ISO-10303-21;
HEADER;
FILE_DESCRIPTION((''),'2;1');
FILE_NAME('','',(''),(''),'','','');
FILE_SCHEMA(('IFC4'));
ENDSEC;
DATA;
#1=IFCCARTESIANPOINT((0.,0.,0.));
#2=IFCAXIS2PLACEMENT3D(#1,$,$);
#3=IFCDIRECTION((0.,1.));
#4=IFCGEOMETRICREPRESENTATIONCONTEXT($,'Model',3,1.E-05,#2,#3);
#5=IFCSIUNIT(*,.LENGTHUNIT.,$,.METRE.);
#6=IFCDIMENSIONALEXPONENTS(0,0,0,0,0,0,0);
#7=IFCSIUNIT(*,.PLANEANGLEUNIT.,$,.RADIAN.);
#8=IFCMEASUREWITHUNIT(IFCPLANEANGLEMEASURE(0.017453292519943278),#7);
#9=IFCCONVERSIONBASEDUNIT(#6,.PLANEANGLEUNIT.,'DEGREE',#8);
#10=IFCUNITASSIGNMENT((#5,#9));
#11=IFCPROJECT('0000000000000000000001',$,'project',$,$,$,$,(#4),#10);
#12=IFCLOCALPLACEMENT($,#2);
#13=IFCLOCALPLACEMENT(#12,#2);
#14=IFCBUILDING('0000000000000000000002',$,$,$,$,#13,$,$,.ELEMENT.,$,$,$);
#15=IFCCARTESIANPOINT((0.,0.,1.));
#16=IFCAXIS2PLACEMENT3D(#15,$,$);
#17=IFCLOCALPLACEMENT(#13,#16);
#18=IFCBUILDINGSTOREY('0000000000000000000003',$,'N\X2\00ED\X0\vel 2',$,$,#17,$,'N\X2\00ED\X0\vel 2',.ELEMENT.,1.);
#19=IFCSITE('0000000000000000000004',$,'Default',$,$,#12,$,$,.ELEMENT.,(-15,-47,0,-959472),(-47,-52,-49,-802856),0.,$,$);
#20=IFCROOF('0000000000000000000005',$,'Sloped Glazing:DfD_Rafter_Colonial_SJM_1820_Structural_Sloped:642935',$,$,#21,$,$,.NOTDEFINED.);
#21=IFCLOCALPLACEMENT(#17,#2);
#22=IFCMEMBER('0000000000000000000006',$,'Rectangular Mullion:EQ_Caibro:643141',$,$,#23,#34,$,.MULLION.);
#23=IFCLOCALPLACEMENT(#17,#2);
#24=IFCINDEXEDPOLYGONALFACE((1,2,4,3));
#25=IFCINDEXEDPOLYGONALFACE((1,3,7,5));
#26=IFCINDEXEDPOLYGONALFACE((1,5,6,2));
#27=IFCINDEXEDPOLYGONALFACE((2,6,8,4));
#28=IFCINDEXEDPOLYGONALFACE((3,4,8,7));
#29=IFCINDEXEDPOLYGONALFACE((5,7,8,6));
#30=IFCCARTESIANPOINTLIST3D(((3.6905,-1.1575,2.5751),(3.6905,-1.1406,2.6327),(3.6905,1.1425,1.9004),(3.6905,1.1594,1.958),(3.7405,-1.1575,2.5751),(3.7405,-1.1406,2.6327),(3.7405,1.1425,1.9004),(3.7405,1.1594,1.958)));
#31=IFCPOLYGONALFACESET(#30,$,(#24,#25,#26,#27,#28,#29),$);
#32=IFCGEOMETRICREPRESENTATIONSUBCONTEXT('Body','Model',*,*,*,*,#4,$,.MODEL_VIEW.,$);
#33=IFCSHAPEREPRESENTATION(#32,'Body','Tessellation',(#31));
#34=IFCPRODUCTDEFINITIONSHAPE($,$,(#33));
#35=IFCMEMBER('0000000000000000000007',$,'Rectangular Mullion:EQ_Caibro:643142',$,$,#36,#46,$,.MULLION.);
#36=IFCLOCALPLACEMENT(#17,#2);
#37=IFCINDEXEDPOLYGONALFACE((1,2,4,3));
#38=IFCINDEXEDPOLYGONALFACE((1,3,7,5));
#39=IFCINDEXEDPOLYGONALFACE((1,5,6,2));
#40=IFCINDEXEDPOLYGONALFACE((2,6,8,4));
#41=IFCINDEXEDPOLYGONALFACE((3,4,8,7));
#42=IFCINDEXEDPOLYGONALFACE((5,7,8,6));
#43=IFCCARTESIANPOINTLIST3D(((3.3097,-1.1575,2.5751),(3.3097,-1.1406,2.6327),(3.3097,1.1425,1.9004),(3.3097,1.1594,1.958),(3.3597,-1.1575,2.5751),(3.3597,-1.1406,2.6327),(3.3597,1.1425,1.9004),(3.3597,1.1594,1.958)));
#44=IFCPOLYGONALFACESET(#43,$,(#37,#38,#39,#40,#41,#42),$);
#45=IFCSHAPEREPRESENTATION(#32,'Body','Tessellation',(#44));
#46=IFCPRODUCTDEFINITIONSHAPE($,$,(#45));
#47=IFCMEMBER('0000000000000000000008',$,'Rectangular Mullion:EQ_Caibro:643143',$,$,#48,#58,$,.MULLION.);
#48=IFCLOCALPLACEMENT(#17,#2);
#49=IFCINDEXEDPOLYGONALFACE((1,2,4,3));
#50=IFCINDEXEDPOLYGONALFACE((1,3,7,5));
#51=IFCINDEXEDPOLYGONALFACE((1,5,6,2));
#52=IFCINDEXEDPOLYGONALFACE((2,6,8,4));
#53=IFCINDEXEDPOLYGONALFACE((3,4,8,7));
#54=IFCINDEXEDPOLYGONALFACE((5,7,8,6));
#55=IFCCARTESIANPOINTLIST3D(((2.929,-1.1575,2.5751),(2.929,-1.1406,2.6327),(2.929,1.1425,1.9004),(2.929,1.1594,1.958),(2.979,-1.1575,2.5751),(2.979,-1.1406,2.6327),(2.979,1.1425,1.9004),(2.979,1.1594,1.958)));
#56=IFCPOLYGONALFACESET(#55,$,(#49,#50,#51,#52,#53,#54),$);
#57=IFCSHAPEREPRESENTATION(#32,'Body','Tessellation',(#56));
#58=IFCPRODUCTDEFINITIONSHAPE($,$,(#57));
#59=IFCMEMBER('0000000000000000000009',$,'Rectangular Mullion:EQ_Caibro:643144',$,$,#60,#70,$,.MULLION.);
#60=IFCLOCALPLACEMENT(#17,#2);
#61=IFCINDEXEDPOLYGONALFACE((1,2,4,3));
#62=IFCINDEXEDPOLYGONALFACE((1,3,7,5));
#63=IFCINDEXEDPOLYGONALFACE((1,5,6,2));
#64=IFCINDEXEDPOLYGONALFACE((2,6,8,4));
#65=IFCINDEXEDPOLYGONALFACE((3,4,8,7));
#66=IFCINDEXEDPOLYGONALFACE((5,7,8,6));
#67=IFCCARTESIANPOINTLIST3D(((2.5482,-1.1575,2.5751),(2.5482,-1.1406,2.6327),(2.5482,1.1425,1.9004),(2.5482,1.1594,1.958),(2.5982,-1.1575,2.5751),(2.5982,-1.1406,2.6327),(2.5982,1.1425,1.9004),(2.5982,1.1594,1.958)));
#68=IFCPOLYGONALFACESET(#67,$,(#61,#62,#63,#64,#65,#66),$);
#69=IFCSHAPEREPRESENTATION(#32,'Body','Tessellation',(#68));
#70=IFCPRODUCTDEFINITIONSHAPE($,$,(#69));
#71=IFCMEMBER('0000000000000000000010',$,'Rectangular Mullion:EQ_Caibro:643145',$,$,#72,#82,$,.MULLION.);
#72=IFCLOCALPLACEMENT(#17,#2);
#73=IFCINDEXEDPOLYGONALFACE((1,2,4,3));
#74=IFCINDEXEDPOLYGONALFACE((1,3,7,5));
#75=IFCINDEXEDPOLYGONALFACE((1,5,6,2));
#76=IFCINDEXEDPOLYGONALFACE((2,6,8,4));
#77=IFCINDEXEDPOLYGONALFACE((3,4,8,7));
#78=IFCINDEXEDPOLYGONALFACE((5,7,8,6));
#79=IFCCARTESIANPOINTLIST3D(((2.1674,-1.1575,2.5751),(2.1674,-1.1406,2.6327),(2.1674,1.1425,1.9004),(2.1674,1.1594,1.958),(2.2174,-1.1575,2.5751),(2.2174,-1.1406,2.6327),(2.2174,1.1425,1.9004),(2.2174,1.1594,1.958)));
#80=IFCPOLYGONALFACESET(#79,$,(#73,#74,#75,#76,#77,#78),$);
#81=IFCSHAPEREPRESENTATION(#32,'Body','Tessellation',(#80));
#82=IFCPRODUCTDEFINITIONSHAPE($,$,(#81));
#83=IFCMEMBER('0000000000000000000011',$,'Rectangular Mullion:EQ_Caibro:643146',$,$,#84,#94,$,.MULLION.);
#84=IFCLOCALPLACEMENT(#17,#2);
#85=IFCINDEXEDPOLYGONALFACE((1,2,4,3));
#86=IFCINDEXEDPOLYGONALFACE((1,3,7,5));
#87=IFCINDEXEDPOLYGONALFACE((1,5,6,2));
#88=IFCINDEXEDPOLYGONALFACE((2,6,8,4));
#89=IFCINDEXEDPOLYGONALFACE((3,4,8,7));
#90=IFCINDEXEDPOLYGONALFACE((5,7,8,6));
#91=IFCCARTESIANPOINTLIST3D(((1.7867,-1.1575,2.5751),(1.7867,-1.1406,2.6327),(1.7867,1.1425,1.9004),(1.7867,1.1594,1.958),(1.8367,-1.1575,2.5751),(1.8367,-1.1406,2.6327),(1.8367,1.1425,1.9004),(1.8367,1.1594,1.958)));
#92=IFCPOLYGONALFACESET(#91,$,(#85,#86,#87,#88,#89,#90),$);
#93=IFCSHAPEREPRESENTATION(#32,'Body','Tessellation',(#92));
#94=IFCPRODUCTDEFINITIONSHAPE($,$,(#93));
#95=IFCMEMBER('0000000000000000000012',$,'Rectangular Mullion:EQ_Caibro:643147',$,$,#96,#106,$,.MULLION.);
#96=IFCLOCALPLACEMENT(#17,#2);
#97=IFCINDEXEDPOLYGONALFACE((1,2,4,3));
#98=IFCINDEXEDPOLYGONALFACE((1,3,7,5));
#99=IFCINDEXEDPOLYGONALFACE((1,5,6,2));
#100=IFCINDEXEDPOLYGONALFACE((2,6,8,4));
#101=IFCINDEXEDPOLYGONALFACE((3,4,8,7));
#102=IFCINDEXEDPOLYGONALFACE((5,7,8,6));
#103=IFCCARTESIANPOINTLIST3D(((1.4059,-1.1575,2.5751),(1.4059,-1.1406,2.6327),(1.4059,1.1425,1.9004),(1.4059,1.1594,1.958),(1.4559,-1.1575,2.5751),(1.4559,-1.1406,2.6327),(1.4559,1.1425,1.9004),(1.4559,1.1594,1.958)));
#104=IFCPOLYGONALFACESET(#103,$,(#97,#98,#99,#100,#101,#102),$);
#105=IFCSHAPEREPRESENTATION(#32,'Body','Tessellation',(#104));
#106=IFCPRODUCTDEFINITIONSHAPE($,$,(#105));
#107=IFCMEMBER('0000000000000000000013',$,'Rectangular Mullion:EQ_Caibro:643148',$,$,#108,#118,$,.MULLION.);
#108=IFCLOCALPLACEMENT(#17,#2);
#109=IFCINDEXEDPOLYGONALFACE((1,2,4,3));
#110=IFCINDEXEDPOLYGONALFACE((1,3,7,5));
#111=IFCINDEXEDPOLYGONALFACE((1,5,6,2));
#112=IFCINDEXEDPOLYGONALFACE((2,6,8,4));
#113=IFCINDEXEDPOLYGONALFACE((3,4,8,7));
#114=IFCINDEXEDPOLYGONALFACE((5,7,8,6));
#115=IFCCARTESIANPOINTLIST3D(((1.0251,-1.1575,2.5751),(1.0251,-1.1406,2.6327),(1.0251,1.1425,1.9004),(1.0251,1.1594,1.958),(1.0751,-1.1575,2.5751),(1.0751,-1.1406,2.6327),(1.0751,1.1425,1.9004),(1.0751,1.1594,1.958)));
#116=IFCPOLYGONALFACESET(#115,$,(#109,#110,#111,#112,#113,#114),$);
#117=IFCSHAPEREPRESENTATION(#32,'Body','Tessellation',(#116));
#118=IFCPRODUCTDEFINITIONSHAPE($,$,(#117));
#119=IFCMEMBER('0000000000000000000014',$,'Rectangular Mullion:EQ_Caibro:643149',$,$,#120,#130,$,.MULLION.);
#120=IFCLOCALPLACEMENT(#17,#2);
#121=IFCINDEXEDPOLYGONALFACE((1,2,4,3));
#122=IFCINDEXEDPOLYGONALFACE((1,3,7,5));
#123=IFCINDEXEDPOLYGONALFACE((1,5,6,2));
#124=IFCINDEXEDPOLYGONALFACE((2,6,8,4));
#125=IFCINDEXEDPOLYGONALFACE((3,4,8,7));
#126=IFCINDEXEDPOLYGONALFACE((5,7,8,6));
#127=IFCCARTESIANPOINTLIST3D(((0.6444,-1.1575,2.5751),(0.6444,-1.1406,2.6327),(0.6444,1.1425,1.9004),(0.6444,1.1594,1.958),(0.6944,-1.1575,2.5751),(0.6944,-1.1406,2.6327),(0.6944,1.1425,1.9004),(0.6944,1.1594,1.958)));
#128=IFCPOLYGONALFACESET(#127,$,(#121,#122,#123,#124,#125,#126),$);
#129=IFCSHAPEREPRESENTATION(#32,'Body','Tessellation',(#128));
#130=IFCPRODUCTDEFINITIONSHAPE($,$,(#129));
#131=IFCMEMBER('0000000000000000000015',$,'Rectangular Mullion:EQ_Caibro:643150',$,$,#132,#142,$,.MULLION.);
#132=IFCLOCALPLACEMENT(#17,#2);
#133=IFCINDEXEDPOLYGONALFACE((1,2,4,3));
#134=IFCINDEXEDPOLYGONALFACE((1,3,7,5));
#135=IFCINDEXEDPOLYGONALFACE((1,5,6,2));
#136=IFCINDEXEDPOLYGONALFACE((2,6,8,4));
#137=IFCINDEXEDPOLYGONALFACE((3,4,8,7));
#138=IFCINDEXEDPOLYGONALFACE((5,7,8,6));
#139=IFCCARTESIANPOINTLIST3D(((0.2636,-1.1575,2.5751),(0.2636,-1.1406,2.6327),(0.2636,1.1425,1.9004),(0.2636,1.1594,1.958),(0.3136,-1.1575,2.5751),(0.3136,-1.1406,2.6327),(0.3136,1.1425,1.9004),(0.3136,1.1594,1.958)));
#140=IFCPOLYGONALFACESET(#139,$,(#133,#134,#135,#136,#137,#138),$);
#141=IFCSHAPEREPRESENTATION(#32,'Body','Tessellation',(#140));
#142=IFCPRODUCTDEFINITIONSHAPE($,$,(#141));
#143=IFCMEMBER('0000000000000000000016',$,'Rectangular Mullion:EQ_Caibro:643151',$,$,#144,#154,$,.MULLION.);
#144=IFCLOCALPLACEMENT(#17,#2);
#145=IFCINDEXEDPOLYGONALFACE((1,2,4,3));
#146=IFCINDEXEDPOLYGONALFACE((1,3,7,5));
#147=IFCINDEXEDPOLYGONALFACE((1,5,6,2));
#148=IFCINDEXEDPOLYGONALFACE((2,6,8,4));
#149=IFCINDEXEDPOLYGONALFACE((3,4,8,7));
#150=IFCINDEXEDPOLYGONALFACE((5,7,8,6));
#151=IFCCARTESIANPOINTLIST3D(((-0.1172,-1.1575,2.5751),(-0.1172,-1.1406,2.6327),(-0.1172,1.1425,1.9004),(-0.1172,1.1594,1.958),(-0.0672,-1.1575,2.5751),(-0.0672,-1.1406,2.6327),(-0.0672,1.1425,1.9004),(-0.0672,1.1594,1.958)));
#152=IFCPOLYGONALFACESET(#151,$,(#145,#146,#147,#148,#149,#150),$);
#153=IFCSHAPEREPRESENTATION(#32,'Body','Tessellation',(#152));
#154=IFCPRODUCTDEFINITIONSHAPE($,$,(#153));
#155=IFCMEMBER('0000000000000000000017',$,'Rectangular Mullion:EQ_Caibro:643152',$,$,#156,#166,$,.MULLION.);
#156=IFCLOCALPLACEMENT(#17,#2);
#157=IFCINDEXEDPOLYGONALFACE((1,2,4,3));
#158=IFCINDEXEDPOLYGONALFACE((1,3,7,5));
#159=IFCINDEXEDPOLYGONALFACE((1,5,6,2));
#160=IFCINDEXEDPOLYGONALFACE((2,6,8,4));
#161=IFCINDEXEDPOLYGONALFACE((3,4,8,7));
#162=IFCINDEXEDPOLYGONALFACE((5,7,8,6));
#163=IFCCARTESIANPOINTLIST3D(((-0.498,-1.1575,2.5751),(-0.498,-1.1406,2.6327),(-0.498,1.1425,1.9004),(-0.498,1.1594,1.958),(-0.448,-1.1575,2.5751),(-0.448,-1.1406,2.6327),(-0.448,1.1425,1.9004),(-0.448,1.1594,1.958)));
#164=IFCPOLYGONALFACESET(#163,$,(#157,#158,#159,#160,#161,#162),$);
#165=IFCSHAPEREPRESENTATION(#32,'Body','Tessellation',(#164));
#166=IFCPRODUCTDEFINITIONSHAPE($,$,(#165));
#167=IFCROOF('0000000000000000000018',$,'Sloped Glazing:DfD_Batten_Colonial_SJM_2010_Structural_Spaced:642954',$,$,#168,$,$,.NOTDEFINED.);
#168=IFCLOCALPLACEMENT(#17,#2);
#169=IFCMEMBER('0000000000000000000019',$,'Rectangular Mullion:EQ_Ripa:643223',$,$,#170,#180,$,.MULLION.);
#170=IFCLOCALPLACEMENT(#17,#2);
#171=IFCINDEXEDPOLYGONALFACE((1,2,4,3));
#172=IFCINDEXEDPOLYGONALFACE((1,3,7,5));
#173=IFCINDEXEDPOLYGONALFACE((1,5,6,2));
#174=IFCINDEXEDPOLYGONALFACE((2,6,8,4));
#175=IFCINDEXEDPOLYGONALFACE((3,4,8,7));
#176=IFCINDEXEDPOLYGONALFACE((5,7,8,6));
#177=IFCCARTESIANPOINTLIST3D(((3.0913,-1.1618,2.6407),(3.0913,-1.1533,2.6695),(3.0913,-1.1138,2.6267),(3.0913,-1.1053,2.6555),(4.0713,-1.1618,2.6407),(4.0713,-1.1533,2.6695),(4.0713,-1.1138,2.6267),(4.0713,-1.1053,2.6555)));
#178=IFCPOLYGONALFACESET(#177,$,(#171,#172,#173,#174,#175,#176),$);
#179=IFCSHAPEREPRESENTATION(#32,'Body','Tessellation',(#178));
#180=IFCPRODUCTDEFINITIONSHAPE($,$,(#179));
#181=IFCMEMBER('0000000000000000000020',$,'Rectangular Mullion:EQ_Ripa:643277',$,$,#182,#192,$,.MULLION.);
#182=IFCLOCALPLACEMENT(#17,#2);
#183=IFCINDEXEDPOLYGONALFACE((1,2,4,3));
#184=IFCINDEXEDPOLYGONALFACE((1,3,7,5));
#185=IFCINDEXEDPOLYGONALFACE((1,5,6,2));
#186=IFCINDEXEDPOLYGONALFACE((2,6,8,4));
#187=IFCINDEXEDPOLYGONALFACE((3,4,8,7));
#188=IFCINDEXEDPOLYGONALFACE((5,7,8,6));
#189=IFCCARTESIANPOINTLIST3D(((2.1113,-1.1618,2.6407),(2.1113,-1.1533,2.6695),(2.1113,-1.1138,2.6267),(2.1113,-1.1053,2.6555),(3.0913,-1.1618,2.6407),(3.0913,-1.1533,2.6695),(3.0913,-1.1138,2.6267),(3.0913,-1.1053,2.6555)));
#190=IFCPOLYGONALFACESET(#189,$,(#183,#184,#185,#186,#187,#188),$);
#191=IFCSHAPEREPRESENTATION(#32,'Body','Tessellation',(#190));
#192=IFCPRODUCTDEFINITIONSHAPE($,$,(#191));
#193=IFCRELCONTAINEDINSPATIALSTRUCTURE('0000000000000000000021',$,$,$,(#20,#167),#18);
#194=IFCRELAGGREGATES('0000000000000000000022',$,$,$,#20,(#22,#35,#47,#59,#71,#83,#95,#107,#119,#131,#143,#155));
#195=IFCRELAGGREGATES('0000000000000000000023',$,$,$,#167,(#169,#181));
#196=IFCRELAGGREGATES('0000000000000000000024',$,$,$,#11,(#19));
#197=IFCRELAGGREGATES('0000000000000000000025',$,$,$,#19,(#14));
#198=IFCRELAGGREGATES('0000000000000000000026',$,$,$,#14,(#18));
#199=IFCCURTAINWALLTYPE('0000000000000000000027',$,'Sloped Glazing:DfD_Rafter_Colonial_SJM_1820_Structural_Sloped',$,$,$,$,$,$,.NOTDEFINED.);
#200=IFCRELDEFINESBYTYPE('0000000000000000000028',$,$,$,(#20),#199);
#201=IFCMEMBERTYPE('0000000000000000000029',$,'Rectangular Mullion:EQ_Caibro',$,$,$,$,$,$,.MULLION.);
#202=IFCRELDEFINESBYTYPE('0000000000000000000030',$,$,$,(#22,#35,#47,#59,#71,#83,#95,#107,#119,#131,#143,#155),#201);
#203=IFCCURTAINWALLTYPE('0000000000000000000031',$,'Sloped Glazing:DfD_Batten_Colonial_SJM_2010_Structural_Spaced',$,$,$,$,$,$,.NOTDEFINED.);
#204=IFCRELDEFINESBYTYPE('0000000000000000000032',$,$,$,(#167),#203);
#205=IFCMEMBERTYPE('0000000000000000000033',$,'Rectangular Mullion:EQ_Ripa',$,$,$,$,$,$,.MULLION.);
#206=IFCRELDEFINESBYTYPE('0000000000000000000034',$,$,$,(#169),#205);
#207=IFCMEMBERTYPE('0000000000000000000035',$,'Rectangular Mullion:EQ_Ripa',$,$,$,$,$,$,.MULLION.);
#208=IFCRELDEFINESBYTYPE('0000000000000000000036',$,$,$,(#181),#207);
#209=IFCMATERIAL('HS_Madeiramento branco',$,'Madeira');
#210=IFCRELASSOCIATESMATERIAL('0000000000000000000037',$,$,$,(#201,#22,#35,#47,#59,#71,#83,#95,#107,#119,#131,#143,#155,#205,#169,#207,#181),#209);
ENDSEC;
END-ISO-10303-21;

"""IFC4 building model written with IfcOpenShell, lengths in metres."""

from ifc_helpers import new_model, entity, si_unit, converted_unit, direction, frame, origin, place, context, subcontext, project, spatial, indexed_curve, outline, extrude, source, transform, mapped, material, type_object, type_shapes, element, aggregate, save


model = new_model("IFC4")

# Units and contexts
model_context = context("Model", 3, precision=1e-05, world=origin(), true_north=direction((0.0, 1.0)))
body_context = subcontext(model_context, "Body", "Model", "MODEL_VIEW")
ifc_project = project(units=[si_unit("LENGTHUNIT", "METRE"), converted_unit("PLANEANGLEUNIT", "DEGREE", entity("IfcPlaneAngleMeasure", 0.017453292519943278), si_unit("PLANEANGLEUNIT", "RADIAN"), dimensions=[0, 0, 0, 0, 0, 0, 0])], contexts=[model_context])

# Site, building, storey
site_placement = place(None, origin())
site = spatial("IfcSite", under=ifc_project, at=site_placement, Name="Default", CompositionType="ELEMENT", RefLatitude=(-15, -47, 0, -959472), RefLongitude=(-47, -52, -49, -802856), RefElevation=0.0)
building_placement = place(site_placement, origin())
building = spatial("IfcBuilding", under=site, at=building_placement, CompositionType="ELEMENT")
storey_placement = place(building_placement, frame((0.0, 0.0, 1.0)))
storey = spatial("IfcBuildingStorey", under=building, at=storey_placement, Name="Nível 2", LongName="Nível 2", CompositionType="ELEMENT", Elevation=1.0)

# Roofs, members
curtain_wall_type_1 = type_object("IfcCurtainWallType", Name="Sloped Glazing:DfD_Rafter_Colonial_SJM_1820_Structural_Sloped", PredefinedType="NOTDEFINED")
roof_1_placement = place(storey_placement, frame((0.0, 0.0, -1.0)))
roof_1 = element("IfcRoof", 1, at=roof_1_placement, inside=storey, type_object=curtain_wall_type_1, Name="Sloped Glazing:DfD_Rafter_Colonial_SJM_1820_Structural_Sloped:642935", PredefinedType="NOTDEFINED")
ifc_material_1 = material(Name="HS_Madeiramento branco", Category="Madeira")
member_type_1 = type_object("IfcMemberType", Name="Rectangular Mullion:EQ_Caibro", PredefinedType="MULLION", material=ifc_material_1)
shared_shape_1 = source(origin(), body_context, "Body", "SweptSolid", [
    extrude(outline(indexed_curve([(-0.025, -0.03), (0.025, -0.03), (0.025, 0.03), (-0.025, 0.03), (-0.025, -0.03)], self_intersect=False)), frame((0.0, -0.03, -2.3969), z_axis=(0.0, 0.0, 1.0), x_axis=(-1.0, 0.0, 0.0)), (0.0, 0.0, 1.0), 2.3969),
])
type_shapes(member_type_1, [shared_shape_1])
member_1_placement = place(roof_1_placement, frame((3.7155, -1.1575, 3.5751), z_axis=(0.0, -0.95956, 0.281504), x_axis=(-1.0, 0.0, 0.0)))
member_1 = element("IfcMember", 2, at=member_1_placement, type_object=member_type_1, material=ifc_material_1, Name="Rectangular Mullion:EQ_Caibro:643141", PredefinedType="MULLION", context=body_context, shape_type="MappedRepresentation", body=[
    mapped(shared_shape_1, transform((0.0, 0.0, 0.0), scale=1.0)),
])
member_2_placement = place(roof_1_placement, frame((3.3347, -1.1575, 3.5751), z_axis=(0.0, -0.95956, 0.281504), x_axis=(-1.0, 0.0, 0.0)))
member_2 = element("IfcMember", 3, at=member_2_placement, type_object=member_type_1, material=ifc_material_1, Name="Rectangular Mullion:EQ_Caibro:643142", PredefinedType="MULLION", context=body_context, shape_type="MappedRepresentation", body=[
    mapped(shared_shape_1, transform((0.0, 0.0, 0.0), scale=1.0)),
])
member_3_placement = place(roof_1_placement, frame((2.954, -1.1575, 3.5751), z_axis=(0.0, -0.95956, 0.281504), x_axis=(-1.0, 0.0, 0.0)))
member_3 = element("IfcMember", 4, at=member_3_placement, type_object=member_type_1, material=ifc_material_1, Name="Rectangular Mullion:EQ_Caibro:643143", PredefinedType="MULLION", context=body_context, shape_type="MappedRepresentation", body=[
    mapped(shared_shape_1, transform((0.0, 0.0, 0.0), scale=1.0)),
])
member_4_placement = place(roof_1_placement, frame((2.5732, -1.1575, 3.5751), z_axis=(0.0, -0.95956, 0.281504), x_axis=(-1.0, 0.0, 0.0)))
member_4 = element("IfcMember", 5, at=member_4_placement, type_object=member_type_1, material=ifc_material_1, Name="Rectangular Mullion:EQ_Caibro:643144", PredefinedType="MULLION", context=body_context, shape_type="MappedRepresentation", body=[
    mapped(shared_shape_1, transform((0.0, 0.0, 0.0), scale=1.0)),
])
member_5_placement = place(roof_1_placement, frame((2.1924, -1.1575, 3.5751), z_axis=(0.0, -0.95956, 0.281504), x_axis=(-1.0, 0.0, 0.0)))
member_5 = element("IfcMember", 6, at=member_5_placement, type_object=member_type_1, material=ifc_material_1, Name="Rectangular Mullion:EQ_Caibro:643145", PredefinedType="MULLION", context=body_context, shape_type="MappedRepresentation", body=[
    mapped(shared_shape_1, transform((0.0, 0.0, 0.0), scale=1.0)),
])
member_6_placement = place(roof_1_placement, frame((1.8117, -1.1575, 3.5751), z_axis=(0.0, -0.95956, 0.281504), x_axis=(-1.0, 0.0, 0.0)))
member_6 = element("IfcMember", 7, at=member_6_placement, type_object=member_type_1, material=ifc_material_1, Name="Rectangular Mullion:EQ_Caibro:643146", PredefinedType="MULLION", context=body_context, shape_type="MappedRepresentation", body=[
    mapped(shared_shape_1, transform((0.0, 0.0, 0.0), scale=1.0)),
])
member_7_placement = place(roof_1_placement, frame((1.4309, -1.1575, 3.5751), z_axis=(0.0, -0.95956, 0.281504), x_axis=(-1.0, 0.0, 0.0)))
member_7 = element("IfcMember", 8, at=member_7_placement, type_object=member_type_1, material=ifc_material_1, Name="Rectangular Mullion:EQ_Caibro:643147", PredefinedType="MULLION", context=body_context, shape_type="MappedRepresentation", body=[
    mapped(shared_shape_1, transform((0.0, 0.0, 0.0), scale=1.0)),
])
member_8_placement = place(roof_1_placement, frame((1.0501, -1.1575, 3.5751), z_axis=(0.0, -0.95956, 0.281504), x_axis=(-1.0, 0.0, 0.0)))
member_8 = element("IfcMember", 9, at=member_8_placement, type_object=member_type_1, material=ifc_material_1, Name="Rectangular Mullion:EQ_Caibro:643148", PredefinedType="MULLION", context=body_context, shape_type="MappedRepresentation", body=[
    mapped(shared_shape_1, transform((0.0, 0.0, 0.0), scale=1.0)),
])
member_9_placement = place(roof_1_placement, frame((0.6694, -1.1575, 3.5751), z_axis=(0.0, -0.95956, 0.281504), x_axis=(-1.0, 0.0, 0.0)))
member_9 = element("IfcMember", 10, at=member_9_placement, type_object=member_type_1, material=ifc_material_1, Name="Rectangular Mullion:EQ_Caibro:643149", PredefinedType="MULLION", context=body_context, shape_type="MappedRepresentation", body=[
    mapped(shared_shape_1, transform((0.0, 0.0, 0.0), scale=1.0)),
])
member_10_placement = place(roof_1_placement, frame((0.2886, -1.1575, 3.5751), z_axis=(0.0, -0.95956, 0.281504), x_axis=(-1.0, 0.0, 0.0)))
member_10 = element("IfcMember", 11, at=member_10_placement, type_object=member_type_1, material=ifc_material_1, Name="Rectangular Mullion:EQ_Caibro:643150", PredefinedType="MULLION", context=body_context, shape_type="MappedRepresentation", body=[
    mapped(shared_shape_1, transform((0.0, 0.0, 0.0), scale=1.0)),
])
member_11_placement = place(roof_1_placement, frame((-0.0922, -1.1575, 3.5751), z_axis=(0.0, -0.95956, 0.281504), x_axis=(-1.0, 0.0, 0.0)))
member_11 = element("IfcMember", 12, at=member_11_placement, type_object=member_type_1, material=ifc_material_1, Name="Rectangular Mullion:EQ_Caibro:643151", PredefinedType="MULLION", context=body_context, shape_type="MappedRepresentation", body=[
    mapped(shared_shape_1, transform((0.0, 0.0, 0.0), scale=1.0)),
])
member_12_placement = place(roof_1_placement, frame((-0.473, -1.1575, 3.5751), z_axis=(0.0, -0.95956, 0.281504), x_axis=(-1.0, 0.0, 0.0)))
member_12 = element("IfcMember", 13, at=member_12_placement, type_object=member_type_1, material=ifc_material_1, Name="Rectangular Mullion:EQ_Caibro:643152", PredefinedType="MULLION", context=body_context, shape_type="MappedRepresentation", body=[
    mapped(shared_shape_1, transform((0.0, 0.0, 0.0), scale=1.0)),
])
aggregate(roof_1, [member_1, member_2, member_3, member_4, member_5, member_6, member_7, member_8, member_9, member_10, member_11, member_12])
curtain_wall_type_2 = type_object("IfcCurtainWallType", Name="Sloped Glazing:DfD_Batten_Colonial_SJM_2010_Structural_Spaced", PredefinedType="NOTDEFINED")
roof_2_placement = place(storey_placement, frame((0.0, 0.0, -1.0)))
roof_2 = element("IfcRoof", 14, at=roof_2_placement, inside=storey, type_object=curtain_wall_type_2, Name="Sloped Glazing:DfD_Batten_Colonial_SJM_2010_Structural_Spaced:642954", PredefinedType="NOTDEFINED")
member_type_2 = type_object("IfcMemberType", Name="Rectangular Mullion:EQ_Ripa", PredefinedType="MULLION", material=ifc_material_1)
shared_shape_2 = source(origin(), body_context, "Body", "SweptSolid", [
    extrude(outline(indexed_curve([(-0.025, -0.015), (0.025, -0.015), (0.025, 0.015), (-0.025, 0.015), (-0.025, -0.015)], self_intersect=False)), frame((-0.025, 0.0, -0.98), z_axis=(0.0, 0.0, 1.0), x_axis=(-1.0, 0.0, 0.0)), (0.0, 0.0, 1.0), 0.98),
])
type_shapes(member_type_2, [shared_shape_2])
member_13_placement = place(roof_2_placement, frame((4.0713, -1.1575, 3.6551), z_axis=(1.0, 0.0, 0.0), x_axis=(0.0, -0.95956, 0.281504)))
member_13 = element("IfcMember", 15, at=member_13_placement, type_object=member_type_2, material=ifc_material_1, Name="Rectangular Mullion:EQ_Ripa:643223", PredefinedType="MULLION", context=body_context, shape_type="MappedRepresentation", body=[
    mapped(shared_shape_2, transform((0.0, 0.0, 0.0), scale=1.0)),
])
member_type_3 = type_object("IfcMemberType", Name="Rectangular Mullion:EQ_Ripa", PredefinedType="MULLION", material=ifc_material_1)
shared_shape_3 = source(origin(), body_context, "Body", "SweptSolid", [
    extrude(outline(indexed_curve([(-0.025, -0.015), (0.025, -0.015), (0.025, 0.015), (-0.025, 0.015), (-0.025, -0.015)], self_intersect=False)), frame((-0.025, 0.0, -0.98), z_axis=(0.0, 0.0, 1.0), x_axis=(-1.0, 0.0, 0.0)), (0.0, 0.0, 1.0), 0.98),
])
type_shapes(member_type_3, [shared_shape_3])
member_14_placement = place(roof_2_placement, frame((3.0913, -1.1575, 3.6551), z_axis=(1.0, 0.0, 0.0), x_axis=(0.0, -0.95956, 0.281504)))
member_14 = element("IfcMember", 16, at=member_14_placement, type_object=member_type_3, material=ifc_material_1, Name="Rectangular Mullion:EQ_Ripa:643277", PredefinedType="MULLION", context=body_context, shape_type="MappedRepresentation", body=[
    mapped(shared_shape_3, transform((0.0, 0.0, 0.0), scale=1.0)),
])
aggregate(roof_2, [member_13, member_14])

save(model, "model.ifc")
